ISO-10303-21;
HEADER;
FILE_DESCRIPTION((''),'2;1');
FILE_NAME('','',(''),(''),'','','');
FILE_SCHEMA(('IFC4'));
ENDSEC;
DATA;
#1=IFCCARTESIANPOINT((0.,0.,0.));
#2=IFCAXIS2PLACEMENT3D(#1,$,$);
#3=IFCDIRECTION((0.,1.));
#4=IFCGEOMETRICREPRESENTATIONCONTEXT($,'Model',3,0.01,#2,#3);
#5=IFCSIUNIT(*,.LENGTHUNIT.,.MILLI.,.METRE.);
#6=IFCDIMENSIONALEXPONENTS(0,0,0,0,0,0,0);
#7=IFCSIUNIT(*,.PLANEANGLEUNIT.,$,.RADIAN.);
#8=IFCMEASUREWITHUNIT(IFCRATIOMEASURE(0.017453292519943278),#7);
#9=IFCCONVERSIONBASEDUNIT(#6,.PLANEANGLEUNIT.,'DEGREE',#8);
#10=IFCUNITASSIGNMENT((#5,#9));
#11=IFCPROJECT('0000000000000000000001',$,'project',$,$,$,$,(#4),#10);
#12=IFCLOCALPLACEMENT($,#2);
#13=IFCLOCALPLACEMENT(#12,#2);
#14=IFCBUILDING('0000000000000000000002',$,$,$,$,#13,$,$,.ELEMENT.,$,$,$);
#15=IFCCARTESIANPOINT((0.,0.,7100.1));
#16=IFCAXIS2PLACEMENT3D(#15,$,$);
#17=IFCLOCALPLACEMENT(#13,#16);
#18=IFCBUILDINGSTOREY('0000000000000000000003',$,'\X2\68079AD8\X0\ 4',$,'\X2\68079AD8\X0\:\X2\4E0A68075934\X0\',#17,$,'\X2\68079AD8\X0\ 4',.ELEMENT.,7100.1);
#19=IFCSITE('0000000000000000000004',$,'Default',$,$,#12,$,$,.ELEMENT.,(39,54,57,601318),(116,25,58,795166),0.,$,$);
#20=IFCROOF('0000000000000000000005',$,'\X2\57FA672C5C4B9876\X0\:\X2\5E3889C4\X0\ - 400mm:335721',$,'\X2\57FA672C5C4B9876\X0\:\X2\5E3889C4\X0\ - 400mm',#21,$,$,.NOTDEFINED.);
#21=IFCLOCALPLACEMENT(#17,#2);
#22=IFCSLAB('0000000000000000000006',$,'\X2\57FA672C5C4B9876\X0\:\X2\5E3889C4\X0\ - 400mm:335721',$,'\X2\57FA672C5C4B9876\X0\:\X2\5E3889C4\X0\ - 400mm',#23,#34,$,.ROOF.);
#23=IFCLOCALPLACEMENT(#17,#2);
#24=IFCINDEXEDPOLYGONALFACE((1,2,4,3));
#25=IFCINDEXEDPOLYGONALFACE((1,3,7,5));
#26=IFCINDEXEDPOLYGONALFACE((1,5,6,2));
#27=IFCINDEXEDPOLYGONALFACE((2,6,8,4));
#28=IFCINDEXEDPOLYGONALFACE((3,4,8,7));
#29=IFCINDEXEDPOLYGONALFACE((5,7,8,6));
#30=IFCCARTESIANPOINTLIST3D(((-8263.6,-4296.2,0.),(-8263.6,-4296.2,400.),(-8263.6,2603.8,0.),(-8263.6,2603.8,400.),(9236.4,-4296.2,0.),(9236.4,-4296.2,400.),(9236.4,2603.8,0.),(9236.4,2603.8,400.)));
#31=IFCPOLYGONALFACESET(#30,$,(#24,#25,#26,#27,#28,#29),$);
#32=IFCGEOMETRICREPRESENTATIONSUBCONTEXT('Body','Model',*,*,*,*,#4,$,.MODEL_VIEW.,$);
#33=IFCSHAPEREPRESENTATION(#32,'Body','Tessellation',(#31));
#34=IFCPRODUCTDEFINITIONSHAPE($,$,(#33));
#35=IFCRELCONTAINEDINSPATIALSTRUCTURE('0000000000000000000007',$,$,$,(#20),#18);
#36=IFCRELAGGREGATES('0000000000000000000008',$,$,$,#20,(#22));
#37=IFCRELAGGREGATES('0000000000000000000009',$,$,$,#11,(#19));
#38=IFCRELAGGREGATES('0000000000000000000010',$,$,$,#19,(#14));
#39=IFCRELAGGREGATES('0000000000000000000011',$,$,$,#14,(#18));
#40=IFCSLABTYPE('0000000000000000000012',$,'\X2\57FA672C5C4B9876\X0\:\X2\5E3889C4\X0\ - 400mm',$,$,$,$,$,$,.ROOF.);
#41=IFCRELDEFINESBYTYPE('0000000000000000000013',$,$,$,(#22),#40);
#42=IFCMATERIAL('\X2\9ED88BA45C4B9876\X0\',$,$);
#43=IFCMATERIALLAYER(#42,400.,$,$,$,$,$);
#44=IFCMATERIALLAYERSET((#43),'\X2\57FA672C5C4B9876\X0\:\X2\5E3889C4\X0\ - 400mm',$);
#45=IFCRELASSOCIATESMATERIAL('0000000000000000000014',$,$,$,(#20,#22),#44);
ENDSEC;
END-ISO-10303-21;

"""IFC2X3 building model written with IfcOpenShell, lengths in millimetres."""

from ifc_helpers import new_model, entity, si_unit, converted_unit, direction, frame, frame_2d, origin, place, context, subcontext, project, spatial, rectangle, extrude, material, layer, layer_set, type_object, element, aggregate, save


model = new_model("IFC2X3")

# Units and contexts
model_context = context("Model", 3, precision=0.01, world=origin(), true_north=direction((0.0, 1.0)))
body_context = subcontext(model_context, "Body", "Model", "MODEL_VIEW")
ifc_project = project(units=[si_unit("LENGTHUNIT", "METRE", prefix="MILLI"), converted_unit("PLANEANGLEUNIT", "DEGREE", entity("IfcRatioMeasure", 0.017453292519943278), si_unit("PLANEANGLEUNIT", "RADIAN"), dimensions=[0, 0, 0, 0, 0, 0, 0])], contexts=[model_context])

# Site, building, storey
site_placement = place(None, origin())
site = spatial("IfcSite", under=ifc_project, at=site_placement, Name="Default", CompositionType="ELEMENT", RefLatitude=(39, 54, 57, 601318), RefLongitude=(116, 25, 58, 795166), RefElevation=0.0)
building_placement = place(site_placement, origin())
building = spatial("IfcBuilding", under=site, at=building_placement, CompositionType="ELEMENT")
storey_placement = place(building_placement, frame((0.0, 0.0, 7100.1)))
storey = spatial("IfcBuildingStorey", under=building, at=storey_placement, Name="标高 4", ObjectType="标高:上标头", LongName="标高 4", CompositionType="ELEMENT", Elevation=7100.1)

# Roof, slab
ifc_material = material(Name="默认屋顶")
ifc_layer = layer(ifc_material, 400.0)
ifc_layer_set = layer_set([ifc_layer], Name="基本屋顶:常规 - 400mm")
roof_placement = place(storey_placement, frame((-8263.6, -4296.2, 0.0)))
roof = element("IfcRoof", 1, at=roof_placement, inside=storey, material=ifc_layer_set, Name="基本屋顶:常规 - 400mm:335721", ObjectType="基本屋顶:常规 - 400mm", ShapeType="NOTDEFINED")
slab_type = type_object("IfcSlabType", Name="基本屋顶:常规 - 400mm", PredefinedType="ROOF")
slab_placement = place(roof_placement, origin())
slab = element("IfcSlab", 2, at=slab_placement, type_object=slab_type, material=ifc_layer_set, Name="基本屋顶:常规 - 400mm:335721", ObjectType="基本屋顶:常规 - 400mm", PredefinedType="ROOF", context=body_context, shape_type="SweptSolid", body=[
    extrude(rectangle(XDim=17500.0, YDim=6900.0, at=frame_2d((0.0, 0.0), x_axis=(-1.0, 0.0))), frame((8750.0, 3450.0, 0.0)), (0.0, 0.0, 1.0), 400.0),
])
aggregate(roof, [slab])

save(model, "model.ifc")
